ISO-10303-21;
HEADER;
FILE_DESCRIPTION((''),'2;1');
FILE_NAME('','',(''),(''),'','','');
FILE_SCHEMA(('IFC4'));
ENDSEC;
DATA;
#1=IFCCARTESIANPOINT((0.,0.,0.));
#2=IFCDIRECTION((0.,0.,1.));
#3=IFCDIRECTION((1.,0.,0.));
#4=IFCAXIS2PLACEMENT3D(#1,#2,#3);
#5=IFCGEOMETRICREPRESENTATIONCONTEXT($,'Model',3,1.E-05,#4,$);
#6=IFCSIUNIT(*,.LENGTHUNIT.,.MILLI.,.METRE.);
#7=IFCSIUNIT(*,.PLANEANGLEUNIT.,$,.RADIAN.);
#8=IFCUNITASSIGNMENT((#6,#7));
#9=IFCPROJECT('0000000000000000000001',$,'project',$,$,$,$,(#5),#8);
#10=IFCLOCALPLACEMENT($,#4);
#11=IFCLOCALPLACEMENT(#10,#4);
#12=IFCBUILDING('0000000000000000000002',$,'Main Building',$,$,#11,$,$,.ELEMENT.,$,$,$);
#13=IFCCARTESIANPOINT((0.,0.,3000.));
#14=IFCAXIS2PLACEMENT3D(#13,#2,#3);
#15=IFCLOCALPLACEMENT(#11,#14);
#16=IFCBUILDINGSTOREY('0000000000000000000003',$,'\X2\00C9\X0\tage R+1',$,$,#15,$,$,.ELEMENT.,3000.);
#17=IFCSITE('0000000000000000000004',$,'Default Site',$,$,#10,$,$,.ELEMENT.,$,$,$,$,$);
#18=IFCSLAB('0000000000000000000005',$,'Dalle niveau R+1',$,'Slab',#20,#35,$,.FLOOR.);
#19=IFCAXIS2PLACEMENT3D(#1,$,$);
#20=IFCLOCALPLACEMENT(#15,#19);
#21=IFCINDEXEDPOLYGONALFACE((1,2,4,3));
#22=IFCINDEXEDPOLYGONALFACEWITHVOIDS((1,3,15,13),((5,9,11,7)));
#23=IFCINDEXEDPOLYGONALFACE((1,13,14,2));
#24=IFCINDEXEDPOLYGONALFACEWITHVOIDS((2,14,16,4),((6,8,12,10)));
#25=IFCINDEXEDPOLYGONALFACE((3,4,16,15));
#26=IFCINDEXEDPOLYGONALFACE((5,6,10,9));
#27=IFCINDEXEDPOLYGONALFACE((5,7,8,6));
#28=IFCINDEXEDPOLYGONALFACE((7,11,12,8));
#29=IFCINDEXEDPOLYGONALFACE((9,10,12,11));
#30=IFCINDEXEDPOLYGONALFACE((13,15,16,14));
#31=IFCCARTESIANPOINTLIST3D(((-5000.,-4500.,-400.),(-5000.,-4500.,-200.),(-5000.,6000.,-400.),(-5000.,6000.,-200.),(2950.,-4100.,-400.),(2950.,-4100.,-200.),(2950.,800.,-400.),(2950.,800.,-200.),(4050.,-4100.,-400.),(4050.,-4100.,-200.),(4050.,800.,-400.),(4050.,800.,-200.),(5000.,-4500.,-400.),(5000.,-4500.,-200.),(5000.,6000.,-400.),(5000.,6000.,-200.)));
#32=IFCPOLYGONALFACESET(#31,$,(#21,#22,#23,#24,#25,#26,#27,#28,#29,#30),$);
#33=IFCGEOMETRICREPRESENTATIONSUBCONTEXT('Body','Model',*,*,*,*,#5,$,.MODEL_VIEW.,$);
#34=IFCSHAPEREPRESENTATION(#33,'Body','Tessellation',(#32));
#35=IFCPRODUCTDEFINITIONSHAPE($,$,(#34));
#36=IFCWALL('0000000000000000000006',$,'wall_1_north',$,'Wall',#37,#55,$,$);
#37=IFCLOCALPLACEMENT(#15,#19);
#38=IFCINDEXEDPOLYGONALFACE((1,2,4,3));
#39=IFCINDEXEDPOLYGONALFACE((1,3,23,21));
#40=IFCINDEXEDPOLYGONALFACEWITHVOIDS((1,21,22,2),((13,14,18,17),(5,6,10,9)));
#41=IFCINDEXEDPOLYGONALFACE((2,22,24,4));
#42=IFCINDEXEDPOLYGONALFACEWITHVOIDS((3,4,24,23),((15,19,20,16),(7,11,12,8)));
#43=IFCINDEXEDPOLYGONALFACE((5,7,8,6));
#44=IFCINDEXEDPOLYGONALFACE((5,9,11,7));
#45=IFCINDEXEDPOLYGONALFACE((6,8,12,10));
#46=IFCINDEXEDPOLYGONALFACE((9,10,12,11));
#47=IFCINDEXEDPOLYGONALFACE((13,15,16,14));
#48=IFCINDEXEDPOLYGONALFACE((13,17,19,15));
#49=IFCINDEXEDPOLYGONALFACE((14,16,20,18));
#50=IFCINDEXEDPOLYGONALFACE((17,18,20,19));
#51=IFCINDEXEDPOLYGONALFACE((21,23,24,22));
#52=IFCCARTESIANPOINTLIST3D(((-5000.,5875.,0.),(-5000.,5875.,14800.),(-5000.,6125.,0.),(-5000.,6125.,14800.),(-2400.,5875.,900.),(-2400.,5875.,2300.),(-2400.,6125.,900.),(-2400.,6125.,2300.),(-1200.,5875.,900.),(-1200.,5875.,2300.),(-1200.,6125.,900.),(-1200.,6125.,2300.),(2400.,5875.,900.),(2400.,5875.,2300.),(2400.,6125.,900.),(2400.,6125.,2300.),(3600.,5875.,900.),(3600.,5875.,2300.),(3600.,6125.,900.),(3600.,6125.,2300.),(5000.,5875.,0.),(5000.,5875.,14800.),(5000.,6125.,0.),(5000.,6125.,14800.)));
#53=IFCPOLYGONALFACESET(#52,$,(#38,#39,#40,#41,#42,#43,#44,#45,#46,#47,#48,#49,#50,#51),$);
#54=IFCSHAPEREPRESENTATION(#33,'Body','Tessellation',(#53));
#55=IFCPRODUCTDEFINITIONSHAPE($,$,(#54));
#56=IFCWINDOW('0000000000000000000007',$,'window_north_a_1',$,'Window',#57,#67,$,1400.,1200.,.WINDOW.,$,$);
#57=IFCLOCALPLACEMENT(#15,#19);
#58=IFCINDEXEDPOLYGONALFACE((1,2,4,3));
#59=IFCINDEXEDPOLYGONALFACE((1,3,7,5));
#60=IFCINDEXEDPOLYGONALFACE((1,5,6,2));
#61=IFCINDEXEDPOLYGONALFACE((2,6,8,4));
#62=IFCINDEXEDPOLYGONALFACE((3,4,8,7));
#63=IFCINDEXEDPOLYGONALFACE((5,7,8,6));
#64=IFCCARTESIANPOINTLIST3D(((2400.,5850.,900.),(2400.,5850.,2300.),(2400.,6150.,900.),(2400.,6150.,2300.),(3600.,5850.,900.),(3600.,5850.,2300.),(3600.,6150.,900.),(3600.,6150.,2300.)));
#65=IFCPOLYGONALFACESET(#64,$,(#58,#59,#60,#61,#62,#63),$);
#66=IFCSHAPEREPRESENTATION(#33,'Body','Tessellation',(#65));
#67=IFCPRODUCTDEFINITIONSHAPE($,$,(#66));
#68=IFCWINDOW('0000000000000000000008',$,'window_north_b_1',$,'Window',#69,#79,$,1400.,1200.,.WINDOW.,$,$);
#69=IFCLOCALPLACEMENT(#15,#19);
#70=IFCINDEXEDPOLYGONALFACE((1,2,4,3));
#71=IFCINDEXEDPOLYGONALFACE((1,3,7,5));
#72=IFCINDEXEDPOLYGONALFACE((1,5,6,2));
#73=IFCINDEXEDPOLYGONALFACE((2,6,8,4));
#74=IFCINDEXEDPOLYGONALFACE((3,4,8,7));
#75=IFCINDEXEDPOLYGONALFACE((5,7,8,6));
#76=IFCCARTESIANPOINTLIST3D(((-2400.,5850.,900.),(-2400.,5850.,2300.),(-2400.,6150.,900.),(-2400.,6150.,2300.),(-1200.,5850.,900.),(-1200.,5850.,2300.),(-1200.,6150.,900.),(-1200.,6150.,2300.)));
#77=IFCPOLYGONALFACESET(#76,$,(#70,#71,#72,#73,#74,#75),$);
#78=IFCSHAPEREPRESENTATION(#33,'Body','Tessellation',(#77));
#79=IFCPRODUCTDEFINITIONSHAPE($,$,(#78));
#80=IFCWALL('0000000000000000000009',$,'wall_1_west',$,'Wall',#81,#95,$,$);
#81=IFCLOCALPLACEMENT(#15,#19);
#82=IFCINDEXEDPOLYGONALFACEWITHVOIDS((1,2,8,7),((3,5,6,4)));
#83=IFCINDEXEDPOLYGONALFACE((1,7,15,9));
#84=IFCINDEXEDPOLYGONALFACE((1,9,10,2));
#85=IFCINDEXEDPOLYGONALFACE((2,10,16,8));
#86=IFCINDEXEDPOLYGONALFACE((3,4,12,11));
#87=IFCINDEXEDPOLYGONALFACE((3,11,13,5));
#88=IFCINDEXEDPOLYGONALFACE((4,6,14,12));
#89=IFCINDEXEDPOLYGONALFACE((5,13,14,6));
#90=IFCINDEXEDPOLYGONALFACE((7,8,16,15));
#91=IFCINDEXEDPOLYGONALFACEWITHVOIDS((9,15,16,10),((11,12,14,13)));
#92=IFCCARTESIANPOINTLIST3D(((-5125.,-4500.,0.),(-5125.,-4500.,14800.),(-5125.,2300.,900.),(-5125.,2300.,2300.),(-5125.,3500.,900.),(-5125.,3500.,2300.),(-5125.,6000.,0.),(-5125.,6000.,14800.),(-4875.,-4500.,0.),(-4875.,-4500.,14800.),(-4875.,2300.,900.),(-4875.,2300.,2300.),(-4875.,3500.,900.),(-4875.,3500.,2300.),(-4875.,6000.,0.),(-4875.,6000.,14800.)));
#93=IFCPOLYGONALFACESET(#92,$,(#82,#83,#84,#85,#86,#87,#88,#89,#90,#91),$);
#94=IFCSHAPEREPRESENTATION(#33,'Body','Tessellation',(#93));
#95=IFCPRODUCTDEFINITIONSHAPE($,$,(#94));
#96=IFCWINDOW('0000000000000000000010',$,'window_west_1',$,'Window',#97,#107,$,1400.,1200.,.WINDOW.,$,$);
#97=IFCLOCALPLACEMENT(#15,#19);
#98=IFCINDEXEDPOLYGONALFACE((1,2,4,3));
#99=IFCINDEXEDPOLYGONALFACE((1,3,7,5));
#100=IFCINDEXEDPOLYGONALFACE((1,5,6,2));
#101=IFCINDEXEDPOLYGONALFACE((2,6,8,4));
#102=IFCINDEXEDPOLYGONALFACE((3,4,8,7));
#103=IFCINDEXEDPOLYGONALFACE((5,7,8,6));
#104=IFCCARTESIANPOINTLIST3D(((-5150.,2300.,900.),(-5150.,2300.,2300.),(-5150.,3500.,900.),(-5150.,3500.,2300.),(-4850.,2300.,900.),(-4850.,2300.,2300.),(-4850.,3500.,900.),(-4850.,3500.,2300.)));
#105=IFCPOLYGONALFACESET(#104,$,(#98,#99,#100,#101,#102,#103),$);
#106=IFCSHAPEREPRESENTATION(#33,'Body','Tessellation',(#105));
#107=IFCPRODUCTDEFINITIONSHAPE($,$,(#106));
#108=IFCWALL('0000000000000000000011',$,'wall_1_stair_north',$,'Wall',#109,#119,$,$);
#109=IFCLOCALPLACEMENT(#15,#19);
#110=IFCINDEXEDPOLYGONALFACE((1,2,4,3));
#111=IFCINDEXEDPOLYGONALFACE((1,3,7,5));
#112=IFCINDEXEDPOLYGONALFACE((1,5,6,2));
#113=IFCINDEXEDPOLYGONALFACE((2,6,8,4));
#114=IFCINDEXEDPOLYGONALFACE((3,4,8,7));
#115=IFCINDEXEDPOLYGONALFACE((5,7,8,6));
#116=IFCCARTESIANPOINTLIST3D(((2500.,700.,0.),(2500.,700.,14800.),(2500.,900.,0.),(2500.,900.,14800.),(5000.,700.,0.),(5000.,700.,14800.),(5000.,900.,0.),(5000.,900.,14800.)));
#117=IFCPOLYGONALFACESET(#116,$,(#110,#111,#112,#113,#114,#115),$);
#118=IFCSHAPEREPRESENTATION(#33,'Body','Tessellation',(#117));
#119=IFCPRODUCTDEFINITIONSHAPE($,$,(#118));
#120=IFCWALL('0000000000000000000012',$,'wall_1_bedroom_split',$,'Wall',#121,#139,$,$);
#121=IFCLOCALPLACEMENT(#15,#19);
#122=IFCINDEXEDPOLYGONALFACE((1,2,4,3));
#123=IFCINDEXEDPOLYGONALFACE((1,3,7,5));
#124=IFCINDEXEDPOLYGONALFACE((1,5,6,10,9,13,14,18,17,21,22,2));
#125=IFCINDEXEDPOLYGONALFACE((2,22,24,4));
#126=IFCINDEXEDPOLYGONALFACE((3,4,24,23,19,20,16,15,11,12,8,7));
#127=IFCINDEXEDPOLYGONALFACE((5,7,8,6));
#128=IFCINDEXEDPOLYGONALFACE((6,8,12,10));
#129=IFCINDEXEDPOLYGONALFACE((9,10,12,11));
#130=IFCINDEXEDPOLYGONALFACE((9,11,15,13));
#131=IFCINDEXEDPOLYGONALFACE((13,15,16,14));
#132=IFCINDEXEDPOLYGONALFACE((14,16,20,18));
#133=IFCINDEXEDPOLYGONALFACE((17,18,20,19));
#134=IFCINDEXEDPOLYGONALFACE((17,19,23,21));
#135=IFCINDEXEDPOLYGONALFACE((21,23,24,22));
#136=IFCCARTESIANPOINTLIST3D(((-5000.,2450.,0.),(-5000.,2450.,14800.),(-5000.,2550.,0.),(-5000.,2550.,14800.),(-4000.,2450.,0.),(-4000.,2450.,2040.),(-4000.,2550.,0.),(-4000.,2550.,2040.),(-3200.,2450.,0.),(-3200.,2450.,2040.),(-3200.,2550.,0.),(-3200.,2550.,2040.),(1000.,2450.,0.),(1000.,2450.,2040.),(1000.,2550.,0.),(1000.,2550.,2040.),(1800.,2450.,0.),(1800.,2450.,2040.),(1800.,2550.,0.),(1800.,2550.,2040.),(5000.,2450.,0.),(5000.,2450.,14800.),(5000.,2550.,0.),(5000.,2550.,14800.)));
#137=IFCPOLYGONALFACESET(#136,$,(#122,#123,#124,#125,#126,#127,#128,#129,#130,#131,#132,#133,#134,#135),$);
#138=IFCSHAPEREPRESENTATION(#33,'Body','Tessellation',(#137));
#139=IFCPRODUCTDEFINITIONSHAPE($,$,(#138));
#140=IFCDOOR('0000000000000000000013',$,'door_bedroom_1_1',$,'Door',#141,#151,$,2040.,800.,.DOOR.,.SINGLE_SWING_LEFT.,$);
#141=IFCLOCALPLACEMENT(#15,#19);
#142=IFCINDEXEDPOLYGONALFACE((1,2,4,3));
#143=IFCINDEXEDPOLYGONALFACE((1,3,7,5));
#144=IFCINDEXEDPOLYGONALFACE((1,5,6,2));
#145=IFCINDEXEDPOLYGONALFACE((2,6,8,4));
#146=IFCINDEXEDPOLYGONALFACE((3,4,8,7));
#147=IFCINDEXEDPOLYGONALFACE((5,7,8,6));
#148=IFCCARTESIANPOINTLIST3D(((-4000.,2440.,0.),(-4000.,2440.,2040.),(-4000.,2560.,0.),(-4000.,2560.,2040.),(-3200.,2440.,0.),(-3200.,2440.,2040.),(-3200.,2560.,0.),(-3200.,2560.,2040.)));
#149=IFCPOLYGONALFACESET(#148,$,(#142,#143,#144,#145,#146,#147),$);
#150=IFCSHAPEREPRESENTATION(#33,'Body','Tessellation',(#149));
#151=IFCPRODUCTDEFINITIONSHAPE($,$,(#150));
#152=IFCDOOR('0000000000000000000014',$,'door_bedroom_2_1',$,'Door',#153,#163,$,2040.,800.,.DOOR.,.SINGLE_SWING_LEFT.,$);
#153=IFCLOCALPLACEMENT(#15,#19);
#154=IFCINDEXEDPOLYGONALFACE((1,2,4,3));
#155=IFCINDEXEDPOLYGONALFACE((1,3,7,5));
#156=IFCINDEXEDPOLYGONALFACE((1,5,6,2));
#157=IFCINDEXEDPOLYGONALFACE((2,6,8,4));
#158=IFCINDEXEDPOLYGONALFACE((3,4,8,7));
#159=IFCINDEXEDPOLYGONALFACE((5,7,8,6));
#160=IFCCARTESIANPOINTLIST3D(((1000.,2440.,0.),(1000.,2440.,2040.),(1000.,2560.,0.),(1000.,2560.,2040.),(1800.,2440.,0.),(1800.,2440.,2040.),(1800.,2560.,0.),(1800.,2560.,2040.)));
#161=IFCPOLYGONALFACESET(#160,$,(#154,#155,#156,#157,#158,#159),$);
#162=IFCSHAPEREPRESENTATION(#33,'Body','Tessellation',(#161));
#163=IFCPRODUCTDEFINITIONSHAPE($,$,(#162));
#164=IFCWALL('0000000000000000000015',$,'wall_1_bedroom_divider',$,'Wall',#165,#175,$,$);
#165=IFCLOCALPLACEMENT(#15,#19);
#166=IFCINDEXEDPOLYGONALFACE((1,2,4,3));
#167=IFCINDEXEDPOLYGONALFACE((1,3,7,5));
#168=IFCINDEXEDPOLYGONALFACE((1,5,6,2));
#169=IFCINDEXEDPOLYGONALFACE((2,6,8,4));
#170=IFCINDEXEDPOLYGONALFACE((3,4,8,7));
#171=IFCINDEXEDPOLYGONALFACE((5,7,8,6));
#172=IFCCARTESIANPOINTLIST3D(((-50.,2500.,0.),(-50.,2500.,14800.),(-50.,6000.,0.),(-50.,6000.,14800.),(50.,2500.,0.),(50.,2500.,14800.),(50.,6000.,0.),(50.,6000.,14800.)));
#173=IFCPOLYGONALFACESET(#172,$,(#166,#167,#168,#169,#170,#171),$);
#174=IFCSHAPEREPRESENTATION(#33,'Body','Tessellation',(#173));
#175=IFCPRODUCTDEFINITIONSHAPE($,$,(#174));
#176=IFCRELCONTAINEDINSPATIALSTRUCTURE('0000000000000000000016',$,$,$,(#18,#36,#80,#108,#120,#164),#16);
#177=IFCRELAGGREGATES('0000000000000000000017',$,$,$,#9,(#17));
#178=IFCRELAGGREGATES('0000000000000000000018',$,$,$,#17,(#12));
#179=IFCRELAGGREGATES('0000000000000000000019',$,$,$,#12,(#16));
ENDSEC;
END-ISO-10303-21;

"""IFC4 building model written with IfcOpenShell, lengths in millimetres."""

from ifc_helpers import new_model, si_unit, frame, origin_with_axes, place, context, subcontext, project, spatial, polyline, outline, extrude, element, fill, save


model = new_model("IFC4")

# Units and contexts
model_context = context("Model", 3, precision=1e-05, world=origin_with_axes())
body_context = subcontext(model_context, "Body", "Model", "MODEL_VIEW")
ifc_project = project(units=[si_unit("LENGTHUNIT", "METRE", prefix="MILLI"), si_unit("PLANEANGLEUNIT", "RADIAN")], contexts=[model_context])

# Site, building, storey
site_placement = place(None, origin_with_axes())
site = spatial("IfcSite", under=ifc_project, at=site_placement, Name="Default Site", CompositionType="ELEMENT")
building_placement = place(site_placement, origin_with_axes())
building = spatial("IfcBuilding", under=site, at=building_placement, Name="Main Building", CompositionType="ELEMENT")
storey_placement = place(building_placement, frame((0.0, 0.0, 3000.0), z_axis=(0.0, 0.0, 1.0), x_axis=(1.0, 0.0, 0.0)))
storey = spatial("IfcBuildingStorey", under=building, at=storey_placement, Name="Étage R+1", CompositionType="ELEMENT", Elevation=3000.0)

# Slab
slab_placement = place(storey_placement, frame((0.0, 0.0, -400.0), z_axis=(0.0, 0.0, 1.0), x_axis=(1.0, 0.0, 0.0)))
element("IfcSlab", 1, at=slab_placement, inside=storey, Name="Dalle niveau R+1", ObjectType="Slab", PredefinedType="FLOOR", context=body_context, shape_type="SweptSolid", body=[
    extrude(outline(polyline([(-5000.0, -4500.0), (5000.0, -4500.0), (5000.0, 6000.0), (-5000.0, 6000.0), (-5000.0, -4500.0)]), holes=[polyline([(2950.0, -4100.0), (2950.0, 800.0), (4050.0, 800.0), (4050.0, -4100.0), (2950.0, -4100.0)])]), origin_with_axes(), (0.0, 0.0, 1.0), 200.0),
])

# Wall, openings, windows
wall_1_placement = place(storey_placement, frame((5000.0, 6000.0, 0.0), z_axis=(0.0, 0.0, 1.0), x_axis=(-1.0, 0.0, 0.0)))
wall_1 = element("IfcWall", 2, at=wall_1_placement, inside=storey, Name="wall_1_north", ObjectType="Wall", context=body_context, shape_type="SweptSolid", body=[
    extrude(outline(polyline([(0.0, -125.0), (10000.0, -125.0), (10000.0, 125.0), (0.0, 125.0), (0.0, -125.0)])), origin_with_axes(), (0.0, 0.0, 1.0), 14800.0),
])
placement_1 = place(wall_1_placement, frame((1400.0, 0.0, 900.0), z_axis=(0.0, 0.0, 1.0), x_axis=(1.0, 0.0, 0.0)))
opening_1 = element("IfcOpeningElement", 3, at=placement_1, cuts=wall_1, PredefinedType="OPENING", context=body_context, shape_type="SweptSolid", body=[
    extrude(outline(polyline([(0.0, -150.0), (1200.0, -150.0), (1200.0, 150.0), (0.0, 150.0), (0.0, -150.0)])), origin_with_axes(), (0.0, 0.0, 1.0), 1400.0),
])
placement_2 = place(wall_1_placement, frame((6200.0, 0.0, 900.0), z_axis=(0.0, 0.0, 1.0), x_axis=(1.0, 0.0, 0.0)))
opening_2 = element("IfcOpeningElement", 4, at=placement_2, cuts=wall_1, PredefinedType="OPENING", context=body_context, shape_type="SweptSolid", body=[
    extrude(outline(polyline([(0.0, -150.0), (1200.0, -150.0), (1200.0, 150.0), (0.0, 150.0), (0.0, -150.0)])), origin_with_axes(), (0.0, 0.0, 1.0), 1400.0),
])
window_1 = element("IfcWindow", 5, at=placement_1, Name="window_north_a_1", ObjectType="Window", OverallHeight=1400.0, OverallWidth=1200.0, PredefinedType="WINDOW", context=body_context, shape_type="SweptSolid", body=[
    extrude(outline(polyline([(0.0, -150.0), (1200.0, -150.0), (1200.0, 150.0), (0.0, 150.0), (0.0, -150.0)])), origin_with_axes(), (0.0, 0.0, 1.0), 1400.0),
])
fill(opening_1, window_1)
window_2 = element("IfcWindow", 6, at=placement_2, Name="window_north_b_1", ObjectType="Window", OverallHeight=1400.0, OverallWidth=1200.0, PredefinedType="WINDOW", context=body_context, shape_type="SweptSolid", body=[
    extrude(outline(polyline([(0.0, -150.0), (1200.0, -150.0), (1200.0, 150.0), (0.0, 150.0), (0.0, -150.0)])), origin_with_axes(), (0.0, 0.0, 1.0), 1400.0),
])
fill(opening_2, window_2)

# Wall, opening, window
wall_2_placement = place(storey_placement, frame((-5000.0, 6000.0, 0.0), z_axis=(0.0, 0.0, 1.0), x_axis=(0.0, -1.0, 0.0)))
wall_2 = element("IfcWall", 7, at=wall_2_placement, inside=storey, Name="wall_1_west", ObjectType="Wall", context=body_context, shape_type="SweptSolid", body=[
    extrude(outline(polyline([(0.0, -125.0), (10500.0, -125.0), (10500.0, 125.0), (0.0, 125.0), (0.0, -125.0)])), origin_with_axes(), (0.0, 0.0, 1.0), 14800.0),
])
placement_3 = place(wall_2_placement, frame((2500.0, 0.0, 900.0), z_axis=(0.0, 0.0, 1.0), x_axis=(1.0, 0.0, 0.0)))
opening_3 = element("IfcOpeningElement", 8, at=placement_3, cuts=wall_2, PredefinedType="OPENING", context=body_context, shape_type="SweptSolid", body=[
    extrude(outline(polyline([(0.0, -150.0), (1200.0, -150.0), (1200.0, 150.0), (0.0, 150.0), (0.0, -150.0)])), origin_with_axes(), (0.0, 0.0, 1.0), 1400.0),
])
window_3 = element("IfcWindow", 9, at=placement_3, Name="window_west_1", ObjectType="Window", OverallHeight=1400.0, OverallWidth=1200.0, PredefinedType="WINDOW", context=body_context, shape_type="SweptSolid", body=[
    extrude(outline(polyline([(0.0, -150.0), (1200.0, -150.0), (1200.0, 150.0), (0.0, 150.0), (0.0, -150.0)])), origin_with_axes(), (0.0, 0.0, 1.0), 1400.0),
])
fill(opening_3, window_3)

# Wall
wall_3_placement = place(storey_placement, frame((2500.0, 800.0, 0.0), z_axis=(0.0, 0.0, 1.0), x_axis=(1.0, 0.0, 0.0)))
element("IfcWall", 10, at=wall_3_placement, inside=storey, Name="wall_1_stair_north", ObjectType="Wall", context=body_context, shape_type="SweptSolid", body=[
    extrude(outline(polyline([(0.0, -100.0), (2500.0, -100.0), (2500.0, 100.0), (0.0, 100.0), (0.0, -100.0)])), origin_with_axes(), (0.0, 0.0, 1.0), 14800.0),
])

# Wall, openings, doors
wall_4_placement = place(storey_placement, frame((-5000.0, 2500.0, 0.0), z_axis=(0.0, 0.0, 1.0), x_axis=(1.0, 0.0, 0.0)))
wall_4 = element("IfcWall", 11, at=wall_4_placement, inside=storey, Name="wall_1_bedroom_split", ObjectType="Wall", context=body_context, shape_type="SweptSolid", body=[
    extrude(outline(polyline([(0.0, -50.0), (10000.0, -50.0), (10000.0, 50.0), (0.0, 50.0), (0.0, -50.0)])), origin_with_axes(), (0.0, 0.0, 1.0), 14800.0),
])
placement_4 = place(wall_4_placement, frame((1000.0, 0.0, 0.0), z_axis=(0.0, 0.0, 1.0), x_axis=(1.0, 0.0, 0.0)))
opening_4 = element("IfcOpeningElement", 12, at=placement_4, cuts=wall_4, PredefinedType="OPENING", context=body_context, shape_type="SweptSolid", body=[
    extrude(outline(polyline([(0.0, -60.0), (800.0, -60.0), (800.0, 60.0), (0.0, 60.0), (0.0, -60.0)])), origin_with_axes(), (0.0, 0.0, 1.0), 2040.0),
])
placement_5 = place(wall_4_placement, frame((6000.0, 0.0, 0.0), z_axis=(0.0, 0.0, 1.0), x_axis=(1.0, 0.0, 0.0)))
opening_5 = element("IfcOpeningElement", 13, at=placement_5, cuts=wall_4, PredefinedType="OPENING", context=body_context, shape_type="SweptSolid", body=[
    extrude(outline(polyline([(0.0, -60.0), (800.0, -60.0), (800.0, 60.0), (0.0, 60.0), (0.0, -60.0)])), origin_with_axes(), (0.0, 0.0, 1.0), 2040.0),
])
door_1 = element("IfcDoor", 14, at=placement_4, Name="door_bedroom_1_1", ObjectType="Door", OperationType="SINGLE_SWING_LEFT", OverallHeight=2040.0, OverallWidth=800.0, PredefinedType="DOOR", context=body_context, shape_type="SweptSolid", body=[
    extrude(outline(polyline([(0.0, -60.0), (800.0, -60.0), (800.0, 60.0), (0.0, 60.0), (0.0, -60.0)])), origin_with_axes(), (0.0, 0.0, 1.0), 2040.0),
])
fill(opening_4, door_1)
door_2 = element("IfcDoor", 15, at=placement_5, Name="door_bedroom_2_1", ObjectType="Door", OperationType="SINGLE_SWING_LEFT", OverallHeight=2040.0, OverallWidth=800.0, PredefinedType="DOOR", context=body_context, shape_type="SweptSolid", body=[
    extrude(outline(polyline([(0.0, -60.0), (800.0, -60.0), (800.0, 60.0), (0.0, 60.0), (0.0, -60.0)])), origin_with_axes(), (0.0, 0.0, 1.0), 2040.0),
])
fill(opening_5, door_2)

# Wall
wall_5_placement = place(storey_placement, frame((0.0, 2500.0, 0.0), z_axis=(0.0, 0.0, 1.0), x_axis=(0.0, 1.0, 0.0)))
element("IfcWall", 16, at=wall_5_placement, inside=storey, Name="wall_1_bedroom_divider", ObjectType="Wall", context=body_context, shape_type="SweptSolid", body=[
    extrude(outline(polyline([(0.0, -50.0), (3500.0, -50.0), (3500.0, 50.0), (0.0, 50.0), (0.0, -50.0)])), origin_with_axes(), (0.0, 0.0, 1.0), 14800.0),
])

save(model, "model.ifc")
